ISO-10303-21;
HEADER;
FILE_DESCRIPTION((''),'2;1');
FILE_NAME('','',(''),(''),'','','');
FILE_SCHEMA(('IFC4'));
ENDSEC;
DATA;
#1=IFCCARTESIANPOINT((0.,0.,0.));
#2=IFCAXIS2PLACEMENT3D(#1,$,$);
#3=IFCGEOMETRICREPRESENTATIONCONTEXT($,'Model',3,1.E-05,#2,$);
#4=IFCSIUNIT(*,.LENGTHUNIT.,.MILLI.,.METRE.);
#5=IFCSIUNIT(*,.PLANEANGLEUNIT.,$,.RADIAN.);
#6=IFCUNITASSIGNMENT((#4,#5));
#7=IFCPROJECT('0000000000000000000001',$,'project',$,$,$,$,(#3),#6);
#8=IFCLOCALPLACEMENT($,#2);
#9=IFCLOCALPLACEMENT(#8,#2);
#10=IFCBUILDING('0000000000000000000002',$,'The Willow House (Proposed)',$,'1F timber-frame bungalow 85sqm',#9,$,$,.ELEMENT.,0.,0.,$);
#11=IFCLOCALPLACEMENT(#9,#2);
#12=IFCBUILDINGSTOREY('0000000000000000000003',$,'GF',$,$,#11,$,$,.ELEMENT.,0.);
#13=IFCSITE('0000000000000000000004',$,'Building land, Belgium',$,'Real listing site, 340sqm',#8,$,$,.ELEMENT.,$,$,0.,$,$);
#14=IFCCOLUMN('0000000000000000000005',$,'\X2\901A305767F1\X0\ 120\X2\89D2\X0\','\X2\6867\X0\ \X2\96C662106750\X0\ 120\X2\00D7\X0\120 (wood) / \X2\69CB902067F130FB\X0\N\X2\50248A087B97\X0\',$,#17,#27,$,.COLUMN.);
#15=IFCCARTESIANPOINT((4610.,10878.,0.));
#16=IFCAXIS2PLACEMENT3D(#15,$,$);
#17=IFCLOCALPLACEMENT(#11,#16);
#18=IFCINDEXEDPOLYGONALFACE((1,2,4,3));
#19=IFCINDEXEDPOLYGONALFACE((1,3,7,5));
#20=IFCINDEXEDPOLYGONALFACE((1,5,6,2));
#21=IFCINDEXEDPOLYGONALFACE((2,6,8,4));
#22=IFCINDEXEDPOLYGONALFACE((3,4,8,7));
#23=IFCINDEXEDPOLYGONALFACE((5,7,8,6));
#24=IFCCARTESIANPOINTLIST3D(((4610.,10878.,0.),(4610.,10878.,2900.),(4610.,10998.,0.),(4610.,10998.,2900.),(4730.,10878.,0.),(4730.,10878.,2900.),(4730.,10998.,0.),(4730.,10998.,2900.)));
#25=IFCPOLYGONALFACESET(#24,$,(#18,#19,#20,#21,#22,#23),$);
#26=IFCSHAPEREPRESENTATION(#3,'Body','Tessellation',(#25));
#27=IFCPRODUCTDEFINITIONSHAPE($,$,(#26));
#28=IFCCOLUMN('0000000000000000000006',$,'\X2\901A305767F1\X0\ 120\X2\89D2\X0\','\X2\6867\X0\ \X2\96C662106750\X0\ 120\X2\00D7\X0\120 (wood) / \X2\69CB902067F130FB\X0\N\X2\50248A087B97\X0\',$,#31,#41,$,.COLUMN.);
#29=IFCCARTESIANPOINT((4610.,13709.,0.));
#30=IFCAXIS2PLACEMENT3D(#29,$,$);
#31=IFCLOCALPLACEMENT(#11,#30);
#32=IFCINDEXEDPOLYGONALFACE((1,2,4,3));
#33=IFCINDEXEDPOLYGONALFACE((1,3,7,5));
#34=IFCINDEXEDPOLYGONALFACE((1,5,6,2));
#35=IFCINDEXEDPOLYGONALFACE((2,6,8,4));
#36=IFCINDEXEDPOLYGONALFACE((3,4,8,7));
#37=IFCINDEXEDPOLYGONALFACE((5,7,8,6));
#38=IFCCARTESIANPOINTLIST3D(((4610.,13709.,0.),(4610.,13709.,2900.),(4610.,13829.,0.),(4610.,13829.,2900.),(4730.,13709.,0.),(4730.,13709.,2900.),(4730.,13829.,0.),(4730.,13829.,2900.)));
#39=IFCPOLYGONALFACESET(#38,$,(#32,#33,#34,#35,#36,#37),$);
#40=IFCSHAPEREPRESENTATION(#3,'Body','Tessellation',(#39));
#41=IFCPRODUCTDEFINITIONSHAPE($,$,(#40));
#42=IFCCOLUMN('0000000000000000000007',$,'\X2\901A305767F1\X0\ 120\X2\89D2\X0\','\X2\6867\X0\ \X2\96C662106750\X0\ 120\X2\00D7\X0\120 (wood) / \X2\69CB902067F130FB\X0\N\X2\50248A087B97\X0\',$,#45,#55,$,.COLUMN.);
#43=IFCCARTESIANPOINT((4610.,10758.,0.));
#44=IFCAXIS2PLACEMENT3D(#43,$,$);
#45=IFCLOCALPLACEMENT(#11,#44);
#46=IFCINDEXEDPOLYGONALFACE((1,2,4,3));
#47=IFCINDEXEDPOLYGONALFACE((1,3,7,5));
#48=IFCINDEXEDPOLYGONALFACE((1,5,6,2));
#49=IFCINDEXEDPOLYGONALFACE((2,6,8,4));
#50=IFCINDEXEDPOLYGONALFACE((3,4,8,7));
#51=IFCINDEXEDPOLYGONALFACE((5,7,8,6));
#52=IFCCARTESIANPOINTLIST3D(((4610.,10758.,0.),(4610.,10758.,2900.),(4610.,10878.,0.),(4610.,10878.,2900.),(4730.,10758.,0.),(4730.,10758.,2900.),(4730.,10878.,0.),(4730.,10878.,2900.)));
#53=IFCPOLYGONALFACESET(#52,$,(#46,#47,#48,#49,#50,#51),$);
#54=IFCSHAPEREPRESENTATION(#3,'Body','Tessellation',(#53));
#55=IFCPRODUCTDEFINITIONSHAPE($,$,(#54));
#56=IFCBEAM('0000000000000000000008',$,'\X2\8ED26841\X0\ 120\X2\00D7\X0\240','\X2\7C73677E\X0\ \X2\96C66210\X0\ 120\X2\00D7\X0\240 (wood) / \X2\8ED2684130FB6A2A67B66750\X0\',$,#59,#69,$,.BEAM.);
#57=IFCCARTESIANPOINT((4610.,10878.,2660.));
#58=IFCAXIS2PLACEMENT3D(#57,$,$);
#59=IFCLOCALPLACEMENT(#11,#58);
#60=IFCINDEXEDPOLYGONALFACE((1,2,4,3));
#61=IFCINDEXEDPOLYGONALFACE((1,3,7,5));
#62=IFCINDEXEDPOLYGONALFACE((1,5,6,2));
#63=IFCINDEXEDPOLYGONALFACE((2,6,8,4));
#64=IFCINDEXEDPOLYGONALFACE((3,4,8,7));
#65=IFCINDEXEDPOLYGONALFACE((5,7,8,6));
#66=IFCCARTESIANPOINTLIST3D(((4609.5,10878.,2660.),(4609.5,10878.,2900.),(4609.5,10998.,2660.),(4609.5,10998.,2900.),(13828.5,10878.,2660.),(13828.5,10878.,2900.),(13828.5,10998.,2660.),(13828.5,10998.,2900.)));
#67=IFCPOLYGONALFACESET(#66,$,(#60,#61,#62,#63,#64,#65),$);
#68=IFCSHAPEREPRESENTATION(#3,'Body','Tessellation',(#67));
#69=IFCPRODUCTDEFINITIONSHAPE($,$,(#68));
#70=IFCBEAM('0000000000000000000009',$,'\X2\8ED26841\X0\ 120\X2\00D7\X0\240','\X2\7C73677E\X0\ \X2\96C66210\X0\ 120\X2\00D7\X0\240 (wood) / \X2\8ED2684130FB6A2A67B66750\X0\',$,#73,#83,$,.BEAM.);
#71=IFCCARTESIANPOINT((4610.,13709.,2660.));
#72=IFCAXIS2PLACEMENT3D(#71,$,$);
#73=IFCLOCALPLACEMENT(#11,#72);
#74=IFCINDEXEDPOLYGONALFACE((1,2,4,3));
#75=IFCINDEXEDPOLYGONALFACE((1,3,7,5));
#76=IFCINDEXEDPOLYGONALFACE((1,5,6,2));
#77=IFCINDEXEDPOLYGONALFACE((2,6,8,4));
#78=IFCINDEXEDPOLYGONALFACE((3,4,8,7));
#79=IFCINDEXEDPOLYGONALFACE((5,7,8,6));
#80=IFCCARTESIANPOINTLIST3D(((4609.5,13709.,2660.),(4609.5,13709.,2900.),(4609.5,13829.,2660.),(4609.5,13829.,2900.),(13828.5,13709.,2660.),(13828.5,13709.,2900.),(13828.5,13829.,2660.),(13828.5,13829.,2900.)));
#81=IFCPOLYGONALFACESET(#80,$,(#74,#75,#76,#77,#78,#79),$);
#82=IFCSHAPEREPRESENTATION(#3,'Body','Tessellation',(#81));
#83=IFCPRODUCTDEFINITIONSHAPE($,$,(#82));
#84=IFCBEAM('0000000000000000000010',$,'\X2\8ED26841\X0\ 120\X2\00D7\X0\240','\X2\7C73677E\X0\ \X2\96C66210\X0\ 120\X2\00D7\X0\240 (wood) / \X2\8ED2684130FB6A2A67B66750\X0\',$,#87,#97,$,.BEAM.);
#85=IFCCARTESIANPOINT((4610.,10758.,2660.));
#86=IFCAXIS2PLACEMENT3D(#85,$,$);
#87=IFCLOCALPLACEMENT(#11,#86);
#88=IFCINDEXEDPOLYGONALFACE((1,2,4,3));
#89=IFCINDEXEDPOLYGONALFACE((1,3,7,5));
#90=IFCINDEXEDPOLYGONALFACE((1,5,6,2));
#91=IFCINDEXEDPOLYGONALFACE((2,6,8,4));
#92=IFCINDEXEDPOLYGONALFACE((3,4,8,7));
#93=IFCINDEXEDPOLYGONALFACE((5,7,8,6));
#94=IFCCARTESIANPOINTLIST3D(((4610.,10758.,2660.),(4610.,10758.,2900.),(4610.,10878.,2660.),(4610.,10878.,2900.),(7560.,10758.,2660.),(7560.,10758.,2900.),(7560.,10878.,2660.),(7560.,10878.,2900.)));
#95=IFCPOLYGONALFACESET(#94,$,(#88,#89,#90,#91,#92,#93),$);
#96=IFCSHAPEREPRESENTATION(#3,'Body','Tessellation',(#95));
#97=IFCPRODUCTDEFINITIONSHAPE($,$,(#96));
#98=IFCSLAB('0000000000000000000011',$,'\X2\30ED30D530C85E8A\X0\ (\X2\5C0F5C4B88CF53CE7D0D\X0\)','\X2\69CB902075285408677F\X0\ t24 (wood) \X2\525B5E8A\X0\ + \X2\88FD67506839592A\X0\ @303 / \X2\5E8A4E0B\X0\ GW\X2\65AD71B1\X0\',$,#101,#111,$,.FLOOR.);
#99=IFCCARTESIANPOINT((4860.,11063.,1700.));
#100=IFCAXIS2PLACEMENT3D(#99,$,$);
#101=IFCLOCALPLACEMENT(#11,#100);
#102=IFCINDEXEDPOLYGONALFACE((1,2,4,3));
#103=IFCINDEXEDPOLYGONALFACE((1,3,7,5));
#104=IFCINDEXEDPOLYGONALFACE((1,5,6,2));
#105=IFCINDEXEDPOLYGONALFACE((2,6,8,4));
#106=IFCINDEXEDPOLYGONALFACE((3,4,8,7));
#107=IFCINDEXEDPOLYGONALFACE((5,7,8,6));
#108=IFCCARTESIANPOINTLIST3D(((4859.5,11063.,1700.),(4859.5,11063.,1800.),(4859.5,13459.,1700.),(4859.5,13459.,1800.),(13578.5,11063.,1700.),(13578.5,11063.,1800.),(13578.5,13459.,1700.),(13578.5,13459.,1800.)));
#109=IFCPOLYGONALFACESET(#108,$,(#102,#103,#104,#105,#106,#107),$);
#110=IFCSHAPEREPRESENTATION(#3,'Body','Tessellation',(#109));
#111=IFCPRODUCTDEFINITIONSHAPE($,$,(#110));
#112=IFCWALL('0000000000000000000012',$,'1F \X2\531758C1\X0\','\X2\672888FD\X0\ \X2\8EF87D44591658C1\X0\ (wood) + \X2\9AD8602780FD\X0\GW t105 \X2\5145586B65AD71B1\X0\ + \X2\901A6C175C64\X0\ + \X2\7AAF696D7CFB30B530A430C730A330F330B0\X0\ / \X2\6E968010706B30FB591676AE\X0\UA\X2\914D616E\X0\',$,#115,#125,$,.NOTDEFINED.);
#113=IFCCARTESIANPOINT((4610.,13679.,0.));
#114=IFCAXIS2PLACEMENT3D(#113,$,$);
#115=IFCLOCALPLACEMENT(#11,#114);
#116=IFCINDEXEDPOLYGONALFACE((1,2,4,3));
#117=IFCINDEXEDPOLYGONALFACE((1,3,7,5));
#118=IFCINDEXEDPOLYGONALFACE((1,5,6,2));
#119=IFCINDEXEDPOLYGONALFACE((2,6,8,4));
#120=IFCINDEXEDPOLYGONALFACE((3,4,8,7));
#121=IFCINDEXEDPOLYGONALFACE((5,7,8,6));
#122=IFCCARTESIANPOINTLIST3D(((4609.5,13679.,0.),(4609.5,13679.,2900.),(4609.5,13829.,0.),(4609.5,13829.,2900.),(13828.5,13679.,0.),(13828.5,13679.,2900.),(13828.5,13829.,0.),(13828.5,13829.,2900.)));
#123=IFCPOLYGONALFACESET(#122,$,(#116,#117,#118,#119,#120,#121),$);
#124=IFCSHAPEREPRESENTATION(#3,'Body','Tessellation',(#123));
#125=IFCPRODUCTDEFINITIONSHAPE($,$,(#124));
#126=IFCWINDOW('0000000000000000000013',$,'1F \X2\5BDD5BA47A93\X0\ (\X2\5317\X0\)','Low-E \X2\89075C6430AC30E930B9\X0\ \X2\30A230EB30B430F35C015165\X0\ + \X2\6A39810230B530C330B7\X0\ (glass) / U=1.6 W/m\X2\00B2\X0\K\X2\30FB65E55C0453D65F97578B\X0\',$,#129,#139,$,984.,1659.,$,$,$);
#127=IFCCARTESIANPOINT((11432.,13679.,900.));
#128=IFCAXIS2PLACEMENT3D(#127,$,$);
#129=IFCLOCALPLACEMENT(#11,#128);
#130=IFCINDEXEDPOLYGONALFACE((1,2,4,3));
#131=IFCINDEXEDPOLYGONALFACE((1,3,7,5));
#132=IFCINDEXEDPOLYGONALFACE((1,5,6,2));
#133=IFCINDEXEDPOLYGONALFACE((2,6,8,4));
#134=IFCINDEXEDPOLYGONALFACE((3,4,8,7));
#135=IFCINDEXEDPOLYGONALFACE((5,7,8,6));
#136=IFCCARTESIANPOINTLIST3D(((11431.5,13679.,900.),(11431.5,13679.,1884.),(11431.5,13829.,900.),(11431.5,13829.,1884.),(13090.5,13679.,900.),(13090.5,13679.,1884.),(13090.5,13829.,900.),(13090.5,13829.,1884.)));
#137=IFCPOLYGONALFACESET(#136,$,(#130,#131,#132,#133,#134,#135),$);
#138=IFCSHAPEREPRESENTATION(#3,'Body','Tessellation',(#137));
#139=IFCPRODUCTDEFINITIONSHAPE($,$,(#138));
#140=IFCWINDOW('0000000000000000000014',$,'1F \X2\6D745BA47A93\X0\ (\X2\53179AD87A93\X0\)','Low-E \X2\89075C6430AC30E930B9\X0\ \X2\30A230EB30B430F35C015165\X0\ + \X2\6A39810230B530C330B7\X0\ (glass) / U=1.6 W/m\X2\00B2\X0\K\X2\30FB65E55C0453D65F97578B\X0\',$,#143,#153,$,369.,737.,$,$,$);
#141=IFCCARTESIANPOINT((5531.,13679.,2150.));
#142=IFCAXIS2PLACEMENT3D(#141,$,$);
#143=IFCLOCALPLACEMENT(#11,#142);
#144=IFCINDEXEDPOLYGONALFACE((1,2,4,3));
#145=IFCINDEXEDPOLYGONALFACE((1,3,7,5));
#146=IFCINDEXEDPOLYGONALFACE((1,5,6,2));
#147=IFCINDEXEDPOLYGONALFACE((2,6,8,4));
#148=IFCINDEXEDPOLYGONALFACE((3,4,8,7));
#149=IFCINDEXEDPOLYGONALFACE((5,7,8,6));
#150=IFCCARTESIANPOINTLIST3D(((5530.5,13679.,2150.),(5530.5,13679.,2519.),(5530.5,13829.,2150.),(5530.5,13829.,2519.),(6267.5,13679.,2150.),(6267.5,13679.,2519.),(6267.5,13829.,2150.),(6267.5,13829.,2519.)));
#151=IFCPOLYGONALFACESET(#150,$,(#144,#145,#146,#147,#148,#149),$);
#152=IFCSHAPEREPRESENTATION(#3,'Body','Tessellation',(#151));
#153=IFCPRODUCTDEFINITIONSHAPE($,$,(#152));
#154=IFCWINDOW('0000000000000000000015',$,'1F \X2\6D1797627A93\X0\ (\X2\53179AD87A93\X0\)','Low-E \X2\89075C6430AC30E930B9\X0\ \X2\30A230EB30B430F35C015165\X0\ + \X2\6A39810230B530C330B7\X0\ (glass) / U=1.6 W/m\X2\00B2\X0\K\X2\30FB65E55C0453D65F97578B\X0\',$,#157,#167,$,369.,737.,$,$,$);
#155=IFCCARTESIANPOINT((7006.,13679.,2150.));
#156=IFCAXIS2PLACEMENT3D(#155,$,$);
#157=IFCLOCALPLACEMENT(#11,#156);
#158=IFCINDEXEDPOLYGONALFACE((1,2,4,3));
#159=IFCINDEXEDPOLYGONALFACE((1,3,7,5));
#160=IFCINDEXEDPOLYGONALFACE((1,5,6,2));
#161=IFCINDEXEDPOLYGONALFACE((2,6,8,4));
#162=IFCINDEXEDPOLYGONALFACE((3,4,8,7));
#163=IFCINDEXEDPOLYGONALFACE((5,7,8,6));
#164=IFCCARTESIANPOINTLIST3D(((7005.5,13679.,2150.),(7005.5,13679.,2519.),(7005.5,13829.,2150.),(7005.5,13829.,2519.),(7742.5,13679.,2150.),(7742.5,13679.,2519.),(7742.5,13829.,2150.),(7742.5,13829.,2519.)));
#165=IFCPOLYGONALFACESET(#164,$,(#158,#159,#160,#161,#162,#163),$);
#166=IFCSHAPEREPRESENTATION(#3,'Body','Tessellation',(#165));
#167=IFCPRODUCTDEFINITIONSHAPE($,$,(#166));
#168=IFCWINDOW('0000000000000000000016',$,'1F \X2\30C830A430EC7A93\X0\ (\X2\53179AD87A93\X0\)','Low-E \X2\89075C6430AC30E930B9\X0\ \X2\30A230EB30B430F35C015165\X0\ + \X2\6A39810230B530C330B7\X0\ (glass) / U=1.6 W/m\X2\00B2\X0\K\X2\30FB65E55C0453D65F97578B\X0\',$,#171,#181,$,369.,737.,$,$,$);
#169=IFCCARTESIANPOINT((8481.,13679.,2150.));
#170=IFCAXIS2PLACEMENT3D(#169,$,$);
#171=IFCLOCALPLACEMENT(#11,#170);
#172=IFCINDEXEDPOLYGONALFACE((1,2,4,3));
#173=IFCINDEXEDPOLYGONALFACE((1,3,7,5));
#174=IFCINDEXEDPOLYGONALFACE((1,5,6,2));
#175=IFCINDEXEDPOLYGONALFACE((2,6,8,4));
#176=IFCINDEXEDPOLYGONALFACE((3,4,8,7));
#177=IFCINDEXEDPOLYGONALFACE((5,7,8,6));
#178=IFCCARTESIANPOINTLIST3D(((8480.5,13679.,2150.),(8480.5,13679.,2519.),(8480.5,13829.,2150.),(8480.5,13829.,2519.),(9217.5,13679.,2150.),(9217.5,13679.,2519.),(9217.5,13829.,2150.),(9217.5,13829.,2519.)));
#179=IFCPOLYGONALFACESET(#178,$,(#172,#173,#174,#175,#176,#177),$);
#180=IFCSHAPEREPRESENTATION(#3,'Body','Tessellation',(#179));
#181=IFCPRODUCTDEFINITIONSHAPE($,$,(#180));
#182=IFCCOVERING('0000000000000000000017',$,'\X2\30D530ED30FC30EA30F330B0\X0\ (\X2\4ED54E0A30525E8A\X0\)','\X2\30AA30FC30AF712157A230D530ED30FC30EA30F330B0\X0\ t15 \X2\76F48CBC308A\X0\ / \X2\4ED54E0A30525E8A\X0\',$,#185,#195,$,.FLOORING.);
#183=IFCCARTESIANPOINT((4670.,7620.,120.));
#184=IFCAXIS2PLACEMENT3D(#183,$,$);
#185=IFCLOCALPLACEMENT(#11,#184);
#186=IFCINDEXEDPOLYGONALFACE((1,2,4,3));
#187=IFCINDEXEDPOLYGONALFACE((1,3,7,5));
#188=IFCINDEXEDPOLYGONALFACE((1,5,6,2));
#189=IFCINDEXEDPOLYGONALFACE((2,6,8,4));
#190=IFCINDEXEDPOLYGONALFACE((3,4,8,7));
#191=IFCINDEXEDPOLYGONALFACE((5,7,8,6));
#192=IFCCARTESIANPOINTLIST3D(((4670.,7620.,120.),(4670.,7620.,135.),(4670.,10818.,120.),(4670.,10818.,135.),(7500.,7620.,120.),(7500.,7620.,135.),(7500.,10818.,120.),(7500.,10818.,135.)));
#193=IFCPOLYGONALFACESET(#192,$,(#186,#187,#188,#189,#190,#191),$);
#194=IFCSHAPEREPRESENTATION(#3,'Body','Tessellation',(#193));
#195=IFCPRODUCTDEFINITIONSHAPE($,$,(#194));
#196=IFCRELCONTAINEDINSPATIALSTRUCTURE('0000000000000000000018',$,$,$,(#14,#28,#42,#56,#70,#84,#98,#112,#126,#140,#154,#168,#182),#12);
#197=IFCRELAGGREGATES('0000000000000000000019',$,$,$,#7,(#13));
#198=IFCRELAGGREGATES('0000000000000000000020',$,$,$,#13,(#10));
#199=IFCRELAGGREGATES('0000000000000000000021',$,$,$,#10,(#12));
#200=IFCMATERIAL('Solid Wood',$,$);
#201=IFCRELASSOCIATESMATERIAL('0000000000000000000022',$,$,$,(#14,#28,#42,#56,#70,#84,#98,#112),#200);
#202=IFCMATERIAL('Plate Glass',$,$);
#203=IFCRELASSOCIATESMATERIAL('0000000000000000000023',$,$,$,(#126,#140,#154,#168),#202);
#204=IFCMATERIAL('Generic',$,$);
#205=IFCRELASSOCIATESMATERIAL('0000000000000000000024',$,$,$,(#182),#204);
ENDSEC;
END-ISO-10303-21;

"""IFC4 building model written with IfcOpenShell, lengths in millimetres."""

from ifc_helpers import new_model, si_unit, frame, frame_2d, origin, place, context, project, spatial, rectangle, extrude, material, element, fill, save


model = new_model("IFC4")

# Units and contexts
model_context = context("Model", 3, precision=1e-05, world=origin())
ifc_project = project(units=[si_unit("LENGTHUNIT", "METRE", prefix="MILLI"), si_unit("PLANEANGLEUNIT", "RADIAN")], contexts=[model_context])

# Site, building, storey
site_placement = place(None, origin())
site = spatial("IfcSite", under=ifc_project, at=site_placement, Name="Building land, Belgium", ObjectType="Real listing site, 340sqm", CompositionType="ELEMENT", RefElevation=0.0)
building_placement = place(site_placement, origin())
building = spatial("IfcBuilding", under=site, at=building_placement, Name="The Willow House (Proposed)", ObjectType="1F timber-frame bungalow 85sqm", CompositionType="ELEMENT", ElevationOfRefHeight=0.0, ElevationOfTerrain=0.0)
storey_placement = place(building_placement, origin())
storey = spatial("IfcBuildingStorey", under=building, at=storey_placement, Name="GF", CompositionType="ELEMENT", Elevation=0.0)

# Columns
ifc_material_1 = material(Name="Solid Wood")
column_1_placement = place(storey_placement, frame((4610.0, 10878.0, 0.0)))
element("IfcColumn", 1, at=column_1_placement, inside=storey, material=ifc_material_1, Name="通し柱 120角", Description="桧 集成材 120×120 (wood) / 構造柱・N値計算", PredefinedType="COLUMN", context=model_context, shape_type="SweptSolid", body=[
    extrude(rectangle(XDim=120.0, YDim=120.0, at=frame_2d((60.0, 60.0))), frame((4610.0, 10878.0, 0.0)), (0.0, 0.0, 1.0), 2900.0),
])
column_2_placement = place(storey_placement, frame((4610.0, 13709.0, 0.0)))
element("IfcColumn", 2, at=column_2_placement, inside=storey, material=ifc_material_1, Name="通し柱 120角", Description="桧 集成材 120×120 (wood) / 構造柱・N値計算", PredefinedType="COLUMN", context=model_context, shape_type="SweptSolid", body=[
    extrude(rectangle(XDim=120.0, YDim=120.0, at=frame_2d((60.0, 60.0))), frame((4610.0, 13709.0, 0.0)), (0.0, 0.0, 1.0), 2900.0),
])
column_3_placement = place(storey_placement, frame((4610.0, 10758.0, 0.0)))
element("IfcColumn", 3, at=column_3_placement, inside=storey, material=ifc_material_1, Name="通し柱 120角", Description="桧 集成材 120×120 (wood) / 構造柱・N値計算", PredefinedType="COLUMN", context=model_context, shape_type="SweptSolid", body=[
    extrude(rectangle(XDim=120.0, YDim=120.0, at=frame_2d((60.0, 60.0))), frame((4610.0, 10758.0, 0.0)), (0.0, 0.0, 1.0), 2900.0),
])

# Beams
beam_1_placement = place(storey_placement, frame((4610.0, 10878.0, 2660.0)))
element("IfcBeam", 4, at=beam_1_placement, inside=storey, material=ifc_material_1, Name="軒桁 120×240", Description="米松 集成 120×240 (wood) / 軒桁・横架材", PredefinedType="BEAM", context=model_context, shape_type="SweptSolid", body=[
    extrude(rectangle(XDim=9219.0, YDim=120.0, at=frame_2d((4609.0, 60.0))), frame((4610.0, 10878.0, 2660.0)), (0.0, 0.0, 1.0), 240.0),
])
beam_2_placement = place(storey_placement, frame((4610.0, 13709.0, 2660.0)))
element("IfcBeam", 5, at=beam_2_placement, inside=storey, material=ifc_material_1, Name="軒桁 120×240", Description="米松 集成 120×240 (wood) / 軒桁・横架材", PredefinedType="BEAM", context=model_context, shape_type="SweptSolid", body=[
    extrude(rectangle(XDim=9219.0, YDim=120.0, at=frame_2d((4609.0, 60.0))), frame((4610.0, 13709.0, 2660.0)), (0.0, 0.0, 1.0), 240.0),
])
beam_3_placement = place(storey_placement, frame((4610.0, 10758.0, 2660.0)))
element("IfcBeam", 6, at=beam_3_placement, inside=storey, material=ifc_material_1, Name="軒桁 120×240", Description="米松 集成 120×240 (wood) / 軒桁・横架材", PredefinedType="BEAM", context=model_context, shape_type="SweptSolid", body=[
    extrude(rectangle(XDim=2950.0, YDim=120.0, at=frame_2d((1475.0, 60.0))), frame((4610.0, 10758.0, 2660.0)), (0.0, 0.0, 1.0), 240.0),
])

# Slab
slab_1_placement = place(storey_placement, frame((4860.0, 11063.0, 1700.0)))
element("IfcSlab", 7, at=slab_1_placement, inside=storey, material=ifc_material_1, Name="ロフト床 (小屋裏収納)", Description="構造用合板 t24 (wood) 剛床 + 製材根太 @303 / 床下 GW断熱", PredefinedType="FLOOR", context=model_context, shape_type="SweptSolid", body=[
    extrude(rectangle(XDim=8719.0, YDim=2396.0, at=frame_2d((4359.0, 1198.0))), frame((4860.0, 11063.0, 1700.0)), (0.0, 0.0, 1.0), 100.0),
])

# Wall, openings, windows
wall_1_placement = place(storey_placement, frame((4610.0, 13679.0, 0.0)))
wall_1 = element("IfcWall", 8, at=wall_1_placement, inside=storey, material=ifc_material_1, Name="1F 北壁", Description="木製 軸組外壁 (wood) + 高性能GW t105 充填断熱 + 通気層 + 窯業系サイディング / 準耐火・外皮UA配慮", PredefinedType="NOTDEFINED", context=model_context, shape_type="SweptSolid", body=[
    extrude(rectangle(XDim=9219.0, YDim=150.0, at=frame_2d((4609.0, 75.0))), frame((4610.0, 13679.0, 0.0)), (0.0, 0.0, 1.0), 2900.0),
])
opening_1_placement = place(storey_placement, frame((11432.0, 13679.0, 900.0)))
opening_1 = element("IfcOpeningElement", 9, at=opening_1_placement, cuts=wall_1, PredefinedType="NOTDEFINED", context=model_context, shape_type="SweptSolid", body=[
    extrude(rectangle(XDim=1659.0, YDim=150.0, at=frame_2d((829.0, 75.0))), frame((11432.0, 13679.0, 900.0)), (0.0, 0.0, 1.0), 984.0),
])
opening_2_placement = place(storey_placement, frame((5531.0, 13679.0, 2150.0)))
opening_2 = element("IfcOpeningElement", 10, at=opening_2_placement, cuts=wall_1, PredefinedType="NOTDEFINED", context=model_context, shape_type="SweptSolid", body=[
    extrude(rectangle(XDim=737.0, YDim=150.0, at=frame_2d((368.0, 75.0))), frame((5531.0, 13679.0, 2150.0)), (0.0, 0.0, 1.0), 369.0),
])
opening_3_placement = place(storey_placement, frame((7006.0, 13679.0, 2150.0)))
opening_3 = element("IfcOpeningElement", 11, at=opening_3_placement, cuts=wall_1, PredefinedType="NOTDEFINED", context=model_context, shape_type="SweptSolid", body=[
    extrude(rectangle(XDim=737.0, YDim=150.0, at=frame_2d((368.0, 75.0))), frame((7006.0, 13679.0, 2150.0)), (0.0, 0.0, 1.0), 369.0),
])
opening_4_placement = place(storey_placement, frame((8481.0, 13679.0, 2150.0)))
opening_4 = element("IfcOpeningElement", 12, at=opening_4_placement, cuts=wall_1, PredefinedType="NOTDEFINED", context=model_context, shape_type="SweptSolid", body=[
    extrude(rectangle(XDim=737.0, YDim=150.0, at=frame_2d((368.0, 75.0))), frame((8481.0, 13679.0, 2150.0)), (0.0, 0.0, 1.0), 369.0),
])
ifc_material_2 = material(Name="Plate Glass")
window_1_placement = place(storey_placement, frame((11432.0, 13679.0, 900.0)))
window_1 = element("IfcWindow", 13, at=window_1_placement, inside=storey, material=ifc_material_2, Name="1F 寝室窓 (北)", Description="Low-E 複層ガラス アルゴン封入 + 樹脂サッシ (glass) / U=1.6 W/m²K・日射取得型", OverallHeight=984.0, OverallWidth=1659.0, context=model_context, shape_type="SweptSolid", body=[
    extrude(rectangle(XDim=1659.0, YDim=150.0, at=frame_2d((829.0, 75.0))), frame((11432.0, 13679.0, 900.0)), (0.0, 0.0, 1.0), 984.0),
])
fill(opening_1, window_1)
window_2_placement = place(storey_placement, frame((5531.0, 13679.0, 2150.0)))
window_2 = element("IfcWindow", 14, at=window_2_placement, inside=storey, material=ifc_material_2, Name="1F 浴室窓 (北高窓)", Description="Low-E 複層ガラス アルゴン封入 + 樹脂サッシ (glass) / U=1.6 W/m²K・日射取得型", OverallHeight=369.0, OverallWidth=737.0, context=model_context, shape_type="SweptSolid", body=[
    extrude(rectangle(XDim=737.0, YDim=150.0, at=frame_2d((368.0, 75.0))), frame((5531.0, 13679.0, 2150.0)), (0.0, 0.0, 1.0), 369.0),
])
fill(opening_2, window_2)
window_3_placement = place(storey_placement, frame((7006.0, 13679.0, 2150.0)))
window_3 = element("IfcWindow", 15, at=window_3_placement, inside=storey, material=ifc_material_2, Name="1F 洗面窓 (北高窓)", Description="Low-E 複層ガラス アルゴン封入 + 樹脂サッシ (glass) / U=1.6 W/m²K・日射取得型", OverallHeight=369.0, OverallWidth=737.0, context=model_context, shape_type="SweptSolid", body=[
    extrude(rectangle(XDim=737.0, YDim=150.0, at=frame_2d((368.0, 75.0))), frame((7006.0, 13679.0, 2150.0)), (0.0, 0.0, 1.0), 369.0),
])
fill(opening_3, window_3)
window_4_placement = place(storey_placement, frame((8481.0, 13679.0, 2150.0)))
window_4 = element("IfcWindow", 16, at=window_4_placement, inside=storey, material=ifc_material_2, Name="1F トイレ窓 (北高窓)", Description="Low-E 複層ガラス アルゴン封入 + 樹脂サッシ (glass) / U=1.6 W/m²K・日射取得型", OverallHeight=369.0, OverallWidth=737.0, context=model_context, shape_type="SweptSolid", body=[
    extrude(rectangle(XDim=737.0, YDim=150.0, at=frame_2d((368.0, 75.0))), frame((8481.0, 13679.0, 2150.0)), (0.0, 0.0, 1.0), 369.0),
])
fill(opening_4, window_4)

# Covering
ifc_material_3 = material(Name="Generic")
covering_1_placement = place(storey_placement, frame((4670.0, 7620.0, 120.0)))
element("IfcCovering", 17, at=covering_1_placement, inside=storey, material=ifc_material_3, Name="フローリング (仕上げ床)", Description="オーク無垢フローリング t15 直貼り / 仕上げ床", PredefinedType="FLOORING", context=model_context, shape_type="SweptSolid", body=[
    extrude(rectangle(XDim=2830.0, YDim=3198.0, at=frame_2d((1415.0, 1599.0))), frame((4670.0, 7620.0, 120.0)), (0.0, 0.0, 1.0), 15.0),
])

save(model, "model.ifc")
